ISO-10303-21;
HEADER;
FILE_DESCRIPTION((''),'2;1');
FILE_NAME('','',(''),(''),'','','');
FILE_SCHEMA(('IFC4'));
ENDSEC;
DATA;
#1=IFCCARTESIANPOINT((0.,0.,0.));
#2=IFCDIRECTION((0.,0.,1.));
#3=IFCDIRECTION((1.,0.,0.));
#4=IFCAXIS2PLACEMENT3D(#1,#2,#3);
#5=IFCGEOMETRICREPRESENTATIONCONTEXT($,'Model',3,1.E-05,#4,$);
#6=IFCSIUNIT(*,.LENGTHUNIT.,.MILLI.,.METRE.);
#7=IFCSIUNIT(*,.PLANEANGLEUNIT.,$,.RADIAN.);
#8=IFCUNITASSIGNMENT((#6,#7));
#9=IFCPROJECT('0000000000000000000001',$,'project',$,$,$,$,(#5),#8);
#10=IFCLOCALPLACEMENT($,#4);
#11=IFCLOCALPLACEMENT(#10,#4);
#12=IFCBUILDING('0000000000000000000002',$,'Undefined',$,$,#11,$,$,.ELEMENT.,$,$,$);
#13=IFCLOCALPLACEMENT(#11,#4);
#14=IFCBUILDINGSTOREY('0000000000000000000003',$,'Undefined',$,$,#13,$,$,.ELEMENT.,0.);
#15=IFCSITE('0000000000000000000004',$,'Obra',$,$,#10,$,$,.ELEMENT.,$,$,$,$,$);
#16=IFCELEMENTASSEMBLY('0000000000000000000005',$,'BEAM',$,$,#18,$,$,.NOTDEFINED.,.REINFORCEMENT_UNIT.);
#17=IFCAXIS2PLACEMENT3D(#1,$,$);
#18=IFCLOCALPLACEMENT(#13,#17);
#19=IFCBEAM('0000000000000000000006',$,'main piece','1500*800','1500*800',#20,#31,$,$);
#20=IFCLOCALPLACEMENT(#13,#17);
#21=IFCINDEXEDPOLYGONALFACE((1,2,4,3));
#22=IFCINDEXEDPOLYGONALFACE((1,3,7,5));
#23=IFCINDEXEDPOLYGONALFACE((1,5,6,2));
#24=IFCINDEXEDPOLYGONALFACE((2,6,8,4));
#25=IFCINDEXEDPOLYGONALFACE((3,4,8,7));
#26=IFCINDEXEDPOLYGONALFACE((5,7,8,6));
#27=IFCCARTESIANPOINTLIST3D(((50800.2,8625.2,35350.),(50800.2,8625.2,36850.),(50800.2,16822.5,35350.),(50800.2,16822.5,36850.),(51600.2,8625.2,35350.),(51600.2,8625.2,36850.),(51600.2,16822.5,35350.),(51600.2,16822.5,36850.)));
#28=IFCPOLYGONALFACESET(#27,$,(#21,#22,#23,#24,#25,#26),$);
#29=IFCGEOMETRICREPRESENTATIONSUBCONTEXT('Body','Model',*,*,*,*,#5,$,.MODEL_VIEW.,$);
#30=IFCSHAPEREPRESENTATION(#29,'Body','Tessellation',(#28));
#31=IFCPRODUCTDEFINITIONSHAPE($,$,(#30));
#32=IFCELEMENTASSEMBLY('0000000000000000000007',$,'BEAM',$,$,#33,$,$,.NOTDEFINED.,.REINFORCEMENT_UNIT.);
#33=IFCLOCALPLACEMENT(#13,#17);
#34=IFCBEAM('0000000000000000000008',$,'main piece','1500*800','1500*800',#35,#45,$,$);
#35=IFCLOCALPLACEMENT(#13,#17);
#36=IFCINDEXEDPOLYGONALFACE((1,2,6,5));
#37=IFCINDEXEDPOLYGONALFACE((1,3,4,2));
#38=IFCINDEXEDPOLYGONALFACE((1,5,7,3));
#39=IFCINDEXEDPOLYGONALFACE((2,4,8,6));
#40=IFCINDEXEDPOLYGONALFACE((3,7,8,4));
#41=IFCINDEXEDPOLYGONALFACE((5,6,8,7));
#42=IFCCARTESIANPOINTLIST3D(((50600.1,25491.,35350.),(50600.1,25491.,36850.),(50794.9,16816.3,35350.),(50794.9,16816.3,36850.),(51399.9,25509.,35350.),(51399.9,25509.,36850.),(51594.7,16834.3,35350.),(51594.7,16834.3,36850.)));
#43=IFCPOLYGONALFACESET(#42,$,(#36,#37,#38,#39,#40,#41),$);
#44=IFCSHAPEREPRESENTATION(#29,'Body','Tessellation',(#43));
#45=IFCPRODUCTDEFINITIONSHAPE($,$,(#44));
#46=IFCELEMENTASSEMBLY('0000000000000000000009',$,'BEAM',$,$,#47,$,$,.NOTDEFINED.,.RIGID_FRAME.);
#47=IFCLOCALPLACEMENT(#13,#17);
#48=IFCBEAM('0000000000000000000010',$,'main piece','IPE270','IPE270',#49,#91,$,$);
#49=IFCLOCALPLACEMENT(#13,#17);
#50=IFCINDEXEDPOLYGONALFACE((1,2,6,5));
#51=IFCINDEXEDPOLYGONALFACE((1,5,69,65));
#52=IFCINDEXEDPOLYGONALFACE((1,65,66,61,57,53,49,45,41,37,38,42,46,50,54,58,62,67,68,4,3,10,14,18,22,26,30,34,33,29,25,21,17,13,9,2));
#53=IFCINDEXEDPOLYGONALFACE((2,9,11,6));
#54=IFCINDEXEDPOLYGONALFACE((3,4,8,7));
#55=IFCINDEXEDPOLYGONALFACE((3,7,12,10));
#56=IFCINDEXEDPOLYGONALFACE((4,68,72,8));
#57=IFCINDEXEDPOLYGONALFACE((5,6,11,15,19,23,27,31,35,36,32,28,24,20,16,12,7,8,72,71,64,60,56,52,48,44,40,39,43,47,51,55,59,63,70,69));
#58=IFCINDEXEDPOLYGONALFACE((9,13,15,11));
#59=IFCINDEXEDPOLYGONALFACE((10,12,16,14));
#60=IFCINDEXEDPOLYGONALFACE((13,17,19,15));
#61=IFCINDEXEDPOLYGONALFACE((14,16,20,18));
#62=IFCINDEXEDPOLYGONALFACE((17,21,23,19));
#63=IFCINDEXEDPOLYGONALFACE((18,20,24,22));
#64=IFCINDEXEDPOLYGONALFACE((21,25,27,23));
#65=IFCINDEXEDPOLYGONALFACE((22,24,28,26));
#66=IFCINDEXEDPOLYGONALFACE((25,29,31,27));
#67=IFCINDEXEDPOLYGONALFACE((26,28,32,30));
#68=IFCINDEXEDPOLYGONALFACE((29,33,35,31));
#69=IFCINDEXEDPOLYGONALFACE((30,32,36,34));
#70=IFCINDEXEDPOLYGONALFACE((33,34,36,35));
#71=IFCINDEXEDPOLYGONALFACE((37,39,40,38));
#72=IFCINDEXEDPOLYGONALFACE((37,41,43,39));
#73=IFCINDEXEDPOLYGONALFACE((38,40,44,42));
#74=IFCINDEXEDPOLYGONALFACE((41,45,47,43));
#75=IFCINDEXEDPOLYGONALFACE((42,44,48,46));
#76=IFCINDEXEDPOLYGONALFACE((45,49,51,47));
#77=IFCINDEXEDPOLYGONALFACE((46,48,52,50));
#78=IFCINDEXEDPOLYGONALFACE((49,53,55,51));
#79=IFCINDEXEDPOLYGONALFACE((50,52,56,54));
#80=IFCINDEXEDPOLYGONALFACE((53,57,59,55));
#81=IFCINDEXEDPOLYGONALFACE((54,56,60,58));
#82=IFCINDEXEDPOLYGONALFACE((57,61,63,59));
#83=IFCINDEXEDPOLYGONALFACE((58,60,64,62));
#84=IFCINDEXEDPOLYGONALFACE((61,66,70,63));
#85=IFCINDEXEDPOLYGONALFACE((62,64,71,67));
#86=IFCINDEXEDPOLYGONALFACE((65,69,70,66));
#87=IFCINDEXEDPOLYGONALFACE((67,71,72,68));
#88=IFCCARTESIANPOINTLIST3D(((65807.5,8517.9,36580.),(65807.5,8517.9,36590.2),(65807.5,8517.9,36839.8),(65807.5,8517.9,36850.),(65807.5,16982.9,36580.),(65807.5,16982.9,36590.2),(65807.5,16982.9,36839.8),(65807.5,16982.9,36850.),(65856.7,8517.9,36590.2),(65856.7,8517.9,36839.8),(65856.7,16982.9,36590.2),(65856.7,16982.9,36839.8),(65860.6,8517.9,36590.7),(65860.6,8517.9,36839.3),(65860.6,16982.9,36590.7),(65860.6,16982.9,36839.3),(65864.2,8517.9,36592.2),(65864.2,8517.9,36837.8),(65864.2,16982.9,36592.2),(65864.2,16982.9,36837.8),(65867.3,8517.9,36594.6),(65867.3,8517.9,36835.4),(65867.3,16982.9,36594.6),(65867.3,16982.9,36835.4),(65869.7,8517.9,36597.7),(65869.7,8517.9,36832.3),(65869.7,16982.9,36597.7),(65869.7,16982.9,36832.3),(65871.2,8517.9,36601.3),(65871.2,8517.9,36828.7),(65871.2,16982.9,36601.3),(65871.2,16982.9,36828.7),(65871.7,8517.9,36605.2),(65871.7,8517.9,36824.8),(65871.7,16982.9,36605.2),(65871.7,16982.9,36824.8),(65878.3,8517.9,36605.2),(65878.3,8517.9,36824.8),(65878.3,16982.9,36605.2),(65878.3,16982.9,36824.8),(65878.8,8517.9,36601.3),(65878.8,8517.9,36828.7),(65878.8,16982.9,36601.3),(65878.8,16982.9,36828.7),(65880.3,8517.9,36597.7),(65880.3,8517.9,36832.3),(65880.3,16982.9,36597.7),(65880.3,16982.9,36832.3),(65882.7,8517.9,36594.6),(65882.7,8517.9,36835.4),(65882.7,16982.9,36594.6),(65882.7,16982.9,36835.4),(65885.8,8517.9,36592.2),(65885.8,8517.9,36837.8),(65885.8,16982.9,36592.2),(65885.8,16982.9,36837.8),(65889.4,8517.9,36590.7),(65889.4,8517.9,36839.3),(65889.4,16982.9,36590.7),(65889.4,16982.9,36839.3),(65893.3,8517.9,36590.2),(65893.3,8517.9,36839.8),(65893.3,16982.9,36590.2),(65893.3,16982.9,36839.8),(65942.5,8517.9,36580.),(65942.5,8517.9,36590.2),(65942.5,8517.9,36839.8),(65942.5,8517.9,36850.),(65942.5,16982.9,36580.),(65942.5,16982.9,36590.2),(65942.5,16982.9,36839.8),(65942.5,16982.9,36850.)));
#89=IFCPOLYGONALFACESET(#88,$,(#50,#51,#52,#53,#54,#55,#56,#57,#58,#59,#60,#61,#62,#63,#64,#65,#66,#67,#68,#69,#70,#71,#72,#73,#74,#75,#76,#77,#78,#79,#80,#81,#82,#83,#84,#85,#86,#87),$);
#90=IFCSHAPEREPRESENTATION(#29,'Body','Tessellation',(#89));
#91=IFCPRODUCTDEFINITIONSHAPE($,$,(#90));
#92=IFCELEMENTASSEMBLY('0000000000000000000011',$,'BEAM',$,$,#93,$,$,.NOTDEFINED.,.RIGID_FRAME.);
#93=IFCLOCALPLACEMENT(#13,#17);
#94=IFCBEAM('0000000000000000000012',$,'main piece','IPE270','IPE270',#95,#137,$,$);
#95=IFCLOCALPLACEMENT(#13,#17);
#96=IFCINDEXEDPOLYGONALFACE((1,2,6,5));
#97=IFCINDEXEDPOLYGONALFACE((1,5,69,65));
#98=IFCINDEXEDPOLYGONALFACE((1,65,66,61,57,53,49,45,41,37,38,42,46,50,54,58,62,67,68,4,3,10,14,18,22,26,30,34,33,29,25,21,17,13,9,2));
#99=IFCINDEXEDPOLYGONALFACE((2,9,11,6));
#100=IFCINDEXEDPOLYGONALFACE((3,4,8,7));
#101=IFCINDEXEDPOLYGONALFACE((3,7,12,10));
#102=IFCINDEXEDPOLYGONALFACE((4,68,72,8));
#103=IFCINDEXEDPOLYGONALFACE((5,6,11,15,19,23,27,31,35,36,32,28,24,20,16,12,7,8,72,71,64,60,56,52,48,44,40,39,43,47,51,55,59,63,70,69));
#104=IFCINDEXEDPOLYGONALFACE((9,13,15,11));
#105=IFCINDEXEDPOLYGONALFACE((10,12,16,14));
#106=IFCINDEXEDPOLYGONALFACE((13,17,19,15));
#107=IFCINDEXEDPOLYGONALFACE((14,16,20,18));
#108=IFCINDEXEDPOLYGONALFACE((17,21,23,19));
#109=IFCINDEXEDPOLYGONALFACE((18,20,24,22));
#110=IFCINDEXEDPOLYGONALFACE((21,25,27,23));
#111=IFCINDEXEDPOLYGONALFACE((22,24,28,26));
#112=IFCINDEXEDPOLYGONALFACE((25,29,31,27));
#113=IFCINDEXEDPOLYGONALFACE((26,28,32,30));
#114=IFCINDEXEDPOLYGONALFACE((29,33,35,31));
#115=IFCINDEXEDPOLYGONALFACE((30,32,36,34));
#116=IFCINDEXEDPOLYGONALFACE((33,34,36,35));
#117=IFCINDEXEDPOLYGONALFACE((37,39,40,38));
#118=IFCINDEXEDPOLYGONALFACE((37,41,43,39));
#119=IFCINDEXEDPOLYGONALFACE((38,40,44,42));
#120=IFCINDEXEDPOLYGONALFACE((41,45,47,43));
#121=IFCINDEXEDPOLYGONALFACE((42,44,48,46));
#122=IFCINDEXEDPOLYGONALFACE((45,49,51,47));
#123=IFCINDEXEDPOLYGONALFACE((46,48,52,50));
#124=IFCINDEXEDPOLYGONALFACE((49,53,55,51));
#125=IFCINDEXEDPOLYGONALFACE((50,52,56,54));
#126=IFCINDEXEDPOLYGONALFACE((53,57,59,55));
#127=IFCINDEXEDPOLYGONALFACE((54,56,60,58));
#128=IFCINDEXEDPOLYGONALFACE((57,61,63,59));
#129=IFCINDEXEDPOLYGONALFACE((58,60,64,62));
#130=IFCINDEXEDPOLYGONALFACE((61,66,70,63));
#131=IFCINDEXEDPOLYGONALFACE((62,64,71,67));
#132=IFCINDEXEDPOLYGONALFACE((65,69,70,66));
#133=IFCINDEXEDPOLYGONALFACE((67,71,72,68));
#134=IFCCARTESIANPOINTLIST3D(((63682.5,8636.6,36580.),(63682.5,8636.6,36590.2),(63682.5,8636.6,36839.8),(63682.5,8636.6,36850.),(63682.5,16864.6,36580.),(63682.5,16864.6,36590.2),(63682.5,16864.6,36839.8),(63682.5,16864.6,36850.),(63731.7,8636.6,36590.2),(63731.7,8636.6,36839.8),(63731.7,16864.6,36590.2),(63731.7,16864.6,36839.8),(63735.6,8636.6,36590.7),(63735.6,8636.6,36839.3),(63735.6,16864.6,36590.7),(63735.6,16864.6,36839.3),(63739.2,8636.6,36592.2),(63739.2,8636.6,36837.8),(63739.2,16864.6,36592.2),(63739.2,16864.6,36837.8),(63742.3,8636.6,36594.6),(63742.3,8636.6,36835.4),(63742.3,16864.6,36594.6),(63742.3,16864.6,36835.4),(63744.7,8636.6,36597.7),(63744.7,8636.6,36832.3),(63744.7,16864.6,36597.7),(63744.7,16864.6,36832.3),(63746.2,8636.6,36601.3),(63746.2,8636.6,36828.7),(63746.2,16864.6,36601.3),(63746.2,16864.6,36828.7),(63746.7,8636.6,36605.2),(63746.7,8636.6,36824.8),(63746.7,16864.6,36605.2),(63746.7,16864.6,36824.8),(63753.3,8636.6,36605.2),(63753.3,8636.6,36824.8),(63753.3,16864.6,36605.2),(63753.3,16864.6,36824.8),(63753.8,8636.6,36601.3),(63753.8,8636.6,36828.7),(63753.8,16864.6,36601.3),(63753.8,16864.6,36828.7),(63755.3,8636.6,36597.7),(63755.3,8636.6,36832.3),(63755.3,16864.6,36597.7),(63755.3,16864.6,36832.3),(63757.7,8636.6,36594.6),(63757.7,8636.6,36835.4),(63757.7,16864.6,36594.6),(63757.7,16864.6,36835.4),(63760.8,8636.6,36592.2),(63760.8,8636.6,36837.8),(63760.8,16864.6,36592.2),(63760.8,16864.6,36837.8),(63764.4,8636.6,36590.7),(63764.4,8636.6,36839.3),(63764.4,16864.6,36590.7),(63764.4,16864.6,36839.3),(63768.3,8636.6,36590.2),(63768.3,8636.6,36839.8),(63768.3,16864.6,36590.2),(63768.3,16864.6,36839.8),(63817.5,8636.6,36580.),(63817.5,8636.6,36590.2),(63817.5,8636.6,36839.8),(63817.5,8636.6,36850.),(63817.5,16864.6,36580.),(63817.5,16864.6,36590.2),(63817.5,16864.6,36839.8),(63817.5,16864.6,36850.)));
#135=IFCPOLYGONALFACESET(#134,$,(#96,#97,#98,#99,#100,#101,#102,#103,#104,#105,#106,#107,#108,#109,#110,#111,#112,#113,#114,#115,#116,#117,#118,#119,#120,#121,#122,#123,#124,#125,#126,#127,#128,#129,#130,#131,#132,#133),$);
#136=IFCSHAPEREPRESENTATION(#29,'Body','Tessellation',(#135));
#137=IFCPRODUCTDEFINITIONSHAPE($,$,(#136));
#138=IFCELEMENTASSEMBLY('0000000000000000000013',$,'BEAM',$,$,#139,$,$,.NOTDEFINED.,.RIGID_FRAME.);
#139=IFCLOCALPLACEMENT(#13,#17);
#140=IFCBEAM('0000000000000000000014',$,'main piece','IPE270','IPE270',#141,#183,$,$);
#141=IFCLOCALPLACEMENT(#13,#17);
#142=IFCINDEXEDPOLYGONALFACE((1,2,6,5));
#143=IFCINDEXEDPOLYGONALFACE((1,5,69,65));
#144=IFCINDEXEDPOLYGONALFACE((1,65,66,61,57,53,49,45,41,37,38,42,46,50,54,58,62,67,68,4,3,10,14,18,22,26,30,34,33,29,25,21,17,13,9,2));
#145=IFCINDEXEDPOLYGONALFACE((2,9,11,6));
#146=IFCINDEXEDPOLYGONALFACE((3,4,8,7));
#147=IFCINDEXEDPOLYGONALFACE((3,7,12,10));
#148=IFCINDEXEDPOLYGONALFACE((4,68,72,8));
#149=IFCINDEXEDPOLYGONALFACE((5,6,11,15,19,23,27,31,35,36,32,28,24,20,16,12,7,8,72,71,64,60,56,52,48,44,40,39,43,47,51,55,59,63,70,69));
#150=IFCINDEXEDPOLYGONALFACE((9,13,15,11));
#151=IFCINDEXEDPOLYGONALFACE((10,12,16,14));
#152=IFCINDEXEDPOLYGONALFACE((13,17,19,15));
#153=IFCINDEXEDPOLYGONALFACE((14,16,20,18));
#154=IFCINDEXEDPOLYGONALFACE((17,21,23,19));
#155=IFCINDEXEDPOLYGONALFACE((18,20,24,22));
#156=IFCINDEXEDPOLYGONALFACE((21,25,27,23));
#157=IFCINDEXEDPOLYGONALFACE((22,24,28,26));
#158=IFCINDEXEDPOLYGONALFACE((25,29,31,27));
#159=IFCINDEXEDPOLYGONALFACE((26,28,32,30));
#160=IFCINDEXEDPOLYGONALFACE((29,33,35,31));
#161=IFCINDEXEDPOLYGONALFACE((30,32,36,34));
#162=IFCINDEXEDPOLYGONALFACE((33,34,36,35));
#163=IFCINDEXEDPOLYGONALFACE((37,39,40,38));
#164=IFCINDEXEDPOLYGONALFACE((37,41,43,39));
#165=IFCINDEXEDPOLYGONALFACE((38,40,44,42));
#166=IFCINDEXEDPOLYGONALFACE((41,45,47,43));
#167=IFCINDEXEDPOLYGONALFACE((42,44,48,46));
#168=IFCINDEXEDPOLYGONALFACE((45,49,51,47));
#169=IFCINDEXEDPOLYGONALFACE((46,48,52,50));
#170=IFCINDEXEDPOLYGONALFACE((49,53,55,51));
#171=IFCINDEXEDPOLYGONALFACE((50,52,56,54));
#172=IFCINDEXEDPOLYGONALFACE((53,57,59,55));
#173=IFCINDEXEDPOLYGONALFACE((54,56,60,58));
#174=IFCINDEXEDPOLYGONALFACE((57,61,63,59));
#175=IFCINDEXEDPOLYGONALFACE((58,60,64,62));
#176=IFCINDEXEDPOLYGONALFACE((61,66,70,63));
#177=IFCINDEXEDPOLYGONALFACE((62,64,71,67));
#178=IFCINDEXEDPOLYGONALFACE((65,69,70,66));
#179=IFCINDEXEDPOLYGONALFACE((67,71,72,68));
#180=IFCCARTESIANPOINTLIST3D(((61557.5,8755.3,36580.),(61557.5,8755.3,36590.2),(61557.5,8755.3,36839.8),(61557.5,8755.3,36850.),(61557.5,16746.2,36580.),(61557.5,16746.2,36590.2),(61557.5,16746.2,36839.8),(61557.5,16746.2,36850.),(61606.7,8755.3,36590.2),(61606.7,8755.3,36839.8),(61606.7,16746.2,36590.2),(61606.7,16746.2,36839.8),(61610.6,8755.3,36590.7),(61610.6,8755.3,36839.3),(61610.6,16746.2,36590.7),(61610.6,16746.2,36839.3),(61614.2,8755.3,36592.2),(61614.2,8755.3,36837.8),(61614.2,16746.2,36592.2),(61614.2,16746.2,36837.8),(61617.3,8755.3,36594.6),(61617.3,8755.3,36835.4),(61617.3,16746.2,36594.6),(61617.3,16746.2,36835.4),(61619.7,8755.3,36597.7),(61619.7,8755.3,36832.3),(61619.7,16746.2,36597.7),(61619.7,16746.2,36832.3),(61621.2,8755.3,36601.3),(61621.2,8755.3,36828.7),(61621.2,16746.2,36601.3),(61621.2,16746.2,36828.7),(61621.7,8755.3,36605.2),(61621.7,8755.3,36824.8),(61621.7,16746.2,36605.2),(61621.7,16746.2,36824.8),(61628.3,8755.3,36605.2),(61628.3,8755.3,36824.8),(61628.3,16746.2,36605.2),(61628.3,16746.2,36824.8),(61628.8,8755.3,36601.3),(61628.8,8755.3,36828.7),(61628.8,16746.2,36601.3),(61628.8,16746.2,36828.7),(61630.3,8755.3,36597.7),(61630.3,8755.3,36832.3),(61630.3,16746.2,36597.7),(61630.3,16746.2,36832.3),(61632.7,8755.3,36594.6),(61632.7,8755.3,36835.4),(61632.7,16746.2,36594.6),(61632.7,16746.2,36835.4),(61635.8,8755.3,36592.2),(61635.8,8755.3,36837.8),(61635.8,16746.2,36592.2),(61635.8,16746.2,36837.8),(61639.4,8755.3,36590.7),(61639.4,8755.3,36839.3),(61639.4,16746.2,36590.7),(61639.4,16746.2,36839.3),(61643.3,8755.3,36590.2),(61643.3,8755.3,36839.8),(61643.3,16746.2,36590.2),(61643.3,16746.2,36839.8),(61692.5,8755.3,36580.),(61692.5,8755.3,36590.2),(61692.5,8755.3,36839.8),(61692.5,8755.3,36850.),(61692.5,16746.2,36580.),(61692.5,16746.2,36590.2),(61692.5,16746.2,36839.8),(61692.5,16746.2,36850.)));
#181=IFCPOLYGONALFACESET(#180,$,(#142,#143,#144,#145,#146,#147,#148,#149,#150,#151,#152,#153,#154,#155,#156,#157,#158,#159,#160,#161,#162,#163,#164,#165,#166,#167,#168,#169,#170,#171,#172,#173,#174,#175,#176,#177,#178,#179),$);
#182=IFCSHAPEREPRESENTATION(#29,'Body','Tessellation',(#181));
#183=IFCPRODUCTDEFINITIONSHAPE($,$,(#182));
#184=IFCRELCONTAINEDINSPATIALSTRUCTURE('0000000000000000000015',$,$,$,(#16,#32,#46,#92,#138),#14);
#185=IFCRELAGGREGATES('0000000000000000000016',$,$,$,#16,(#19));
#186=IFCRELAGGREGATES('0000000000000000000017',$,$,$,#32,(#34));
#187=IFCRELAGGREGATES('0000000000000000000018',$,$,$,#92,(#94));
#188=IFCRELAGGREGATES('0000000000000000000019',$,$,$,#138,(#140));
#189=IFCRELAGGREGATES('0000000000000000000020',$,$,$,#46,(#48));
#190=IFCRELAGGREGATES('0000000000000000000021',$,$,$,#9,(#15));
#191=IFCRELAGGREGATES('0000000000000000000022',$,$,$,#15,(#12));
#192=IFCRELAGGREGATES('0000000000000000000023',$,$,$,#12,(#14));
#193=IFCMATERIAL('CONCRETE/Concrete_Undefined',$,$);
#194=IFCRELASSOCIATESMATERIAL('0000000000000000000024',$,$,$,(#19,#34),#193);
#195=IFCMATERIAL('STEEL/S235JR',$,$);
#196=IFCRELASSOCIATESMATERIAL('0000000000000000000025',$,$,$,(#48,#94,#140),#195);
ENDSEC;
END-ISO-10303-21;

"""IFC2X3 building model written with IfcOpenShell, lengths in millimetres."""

from ifc_helpers import new_model, si_unit, frame, origin_with_axes, origin_2d_with_axis, place, context, subcontext, project, spatial, rectangle, i_section, extrude, material, element, aggregate, save


model = new_model("IFC2X3")

# Units and contexts
model_context = context("Model", 3, precision=1e-05, world=origin_with_axes())
body_context = subcontext(model_context, "Body", "Model", "MODEL_VIEW")
ifc_project = project(units=[si_unit("LENGTHUNIT", "METRE", prefix="MILLI"), si_unit("PLANEANGLEUNIT", "RADIAN")], contexts=[model_context])

# Site, building, storey
site_placement = place(None, origin_with_axes())
site = spatial("IfcSite", under=ifc_project, at=site_placement, Name="Obra", CompositionType="ELEMENT")
building_placement = place(site_placement, origin_with_axes())
building = spatial("IfcBuilding", under=site, at=building_placement, Name="Undefined", CompositionType="ELEMENT")
storey_placement = place(building_placement, origin_with_axes())
storey = spatial("IfcBuildingStorey", under=building, at=storey_placement, Name="Undefined", CompositionType="ELEMENT", Elevation=0.0)

# Element assemblies, beams
assembly_1_placement = place(storey_placement, origin_with_axes())
assembly_1 = element("IfcElementAssembly", 1, at=assembly_1_placement, inside=storey, Name="BEAM", AssemblyPlace="NOTDEFINED", PredefinedType="REINFORCEMENT_UNIT")
ifc_material_1 = material(Name="CONCRETE/Concrete_Undefined")
beam_1_placement = place(assembly_1_placement, frame((51200.2, 8625.2, 36100.0), z_axis=(0.0, 0.0, 1.0), x_axis=(0.0, 1.0, 0.0)))
beam_1 = element("IfcBeam", 2, at=beam_1_placement, material=ifc_material_1, Name="main piece", Description="1500*800", ObjectType="1500*800", context=body_context, shape_type="SweptSolid", body=[
    extrude(rectangle(XDim=800.0, YDim=1500.0, at=origin_2d_with_axis()), frame((8197.3, 0.0, 0.0), z_axis=(-1.0, 0.0, 0.0), x_axis=(0.0, -1.0, 0.0)), (0.0, 0.0, 1.0), 8197.3),
])
aggregate(assembly_1, [beam_1])
assembly_2_placement = place(storey_placement, origin_with_axes())
assembly_2 = element("IfcElementAssembly", 3, at=assembly_2_placement, inside=storey, Name="BEAM", AssemblyPlace="NOTDEFINED", PredefinedType="REINFORCEMENT_UNIT")
beam_2_placement = place(assembly_2_placement, frame((51194.8, 16825.3, 36100.0), z_axis=(0.0, 0.0, 1.0), x_axis=(-0.022453, 0.999748, 0.0)))
beam_2 = element("IfcBeam", 4, at=beam_2_placement, material=ifc_material_1, Name="main piece", Description="1500*800", ObjectType="1500*800", context=body_context, shape_type="SweptSolid", body=[
    extrude(rectangle(XDim=800.0, YDim=1500.0, at=origin_2d_with_axis()), frame((8676.9, 0.0, 0.0), z_axis=(-1.0, 0.0, 0.0), x_axis=(0.0, -1.0, 0.0)), (0.0, 0.0, 1.0), 8676.9),
])
aggregate(assembly_2, [beam_2])
assembly_3_placement = place(storey_placement, origin_with_axes())
assembly_3 = element("IfcElementAssembly", 5, at=assembly_3_placement, inside=storey, Name="BEAM", AssemblyPlace="NOTDEFINED", PredefinedType="RIGID_FRAME")
ifc_material_2 = material(Name="STEEL/S235JR")
beam_3_placement = place(assembly_3_placement, frame((65875.0, 8517.9, 36715.0), z_axis=(0.0, 0.0, 1.0), x_axis=(0.0, 1.0, 0.0)))
beam_3 = element("IfcBeam", 6, at=beam_3_placement, material=ifc_material_2, Name="main piece", Description="IPE270", ObjectType="IPE270", context=body_context, shape_type="SweptSolid", body=[
    extrude(i_section(OverallWidth=135.0, OverallDepth=270.0, WebThickness=6.6, FlangeThickness=10.2, FilletRadius=15.0, at=origin_2d_with_axis()), frame((8465.0, 0.0, 0.0), z_axis=(-1.0, 0.0, 0.0), x_axis=(0.0, -1.0, 0.0)), (0.0, 0.0, 1.0), 8465.0),
])
assembly_4_placement = place(storey_placement, origin_with_axes())
assembly_4 = element("IfcElementAssembly", 7, at=assembly_4_placement, inside=storey, Name="BEAM", AssemblyPlace="NOTDEFINED", PredefinedType="RIGID_FRAME")
beam_4_placement = place(assembly_4_placement, frame((63750.0, 16864.6, 36715.0), z_axis=(0.0, 0.0, 1.0), x_axis=(0.0, -1.0, 0.0)))
beam_4 = element("IfcBeam", 8, at=beam_4_placement, material=ifc_material_2, Name="main piece", Description="IPE270", ObjectType="IPE270", context=body_context, shape_type="SweptSolid", body=[
    extrude(i_section(OverallWidth=135.0, OverallDepth=270.0, WebThickness=6.6, FlangeThickness=10.2, FilletRadius=15.0, at=origin_2d_with_axis()), frame((8228.0, 0.0, 0.0), z_axis=(-1.0, 0.0, 0.0), x_axis=(0.0, -1.0, 0.0)), (0.0, 0.0, 1.0), 8228.0),
])
aggregate(assembly_4, [beam_4])
assembly_5_placement = place(storey_placement, origin_with_axes())
assembly_5 = element("IfcElementAssembly", 9, at=assembly_5_placement, inside=storey, Name="BEAM", AssemblyPlace="NOTDEFINED", PredefinedType="RIGID_FRAME")
beam_5_placement = place(assembly_5_placement, frame((61625.0, 8755.3, 36715.0), z_axis=(0.0, 0.0, 1.0), x_axis=(0.0, 1.0, 0.0)))
beam_5 = element("IfcBeam", 10, at=beam_5_placement, material=ifc_material_2, Name="main piece", Description="IPE270", ObjectType="IPE270", context=body_context, shape_type="SweptSolid", body=[
    extrude(i_section(OverallWidth=135.0, OverallDepth=270.0, WebThickness=6.6, FlangeThickness=10.2, FilletRadius=15.0, at=origin_2d_with_axis()), frame((7990.9, 0.0, 0.0), z_axis=(-1.0, 0.0, 0.0), x_axis=(0.0, -1.0, 0.0)), (0.0, 0.0, 1.0), 7990.9),
])
aggregate(assembly_5, [beam_5])

aggregate(assembly_3, [beam_3])

save(model, "model.ifc")
